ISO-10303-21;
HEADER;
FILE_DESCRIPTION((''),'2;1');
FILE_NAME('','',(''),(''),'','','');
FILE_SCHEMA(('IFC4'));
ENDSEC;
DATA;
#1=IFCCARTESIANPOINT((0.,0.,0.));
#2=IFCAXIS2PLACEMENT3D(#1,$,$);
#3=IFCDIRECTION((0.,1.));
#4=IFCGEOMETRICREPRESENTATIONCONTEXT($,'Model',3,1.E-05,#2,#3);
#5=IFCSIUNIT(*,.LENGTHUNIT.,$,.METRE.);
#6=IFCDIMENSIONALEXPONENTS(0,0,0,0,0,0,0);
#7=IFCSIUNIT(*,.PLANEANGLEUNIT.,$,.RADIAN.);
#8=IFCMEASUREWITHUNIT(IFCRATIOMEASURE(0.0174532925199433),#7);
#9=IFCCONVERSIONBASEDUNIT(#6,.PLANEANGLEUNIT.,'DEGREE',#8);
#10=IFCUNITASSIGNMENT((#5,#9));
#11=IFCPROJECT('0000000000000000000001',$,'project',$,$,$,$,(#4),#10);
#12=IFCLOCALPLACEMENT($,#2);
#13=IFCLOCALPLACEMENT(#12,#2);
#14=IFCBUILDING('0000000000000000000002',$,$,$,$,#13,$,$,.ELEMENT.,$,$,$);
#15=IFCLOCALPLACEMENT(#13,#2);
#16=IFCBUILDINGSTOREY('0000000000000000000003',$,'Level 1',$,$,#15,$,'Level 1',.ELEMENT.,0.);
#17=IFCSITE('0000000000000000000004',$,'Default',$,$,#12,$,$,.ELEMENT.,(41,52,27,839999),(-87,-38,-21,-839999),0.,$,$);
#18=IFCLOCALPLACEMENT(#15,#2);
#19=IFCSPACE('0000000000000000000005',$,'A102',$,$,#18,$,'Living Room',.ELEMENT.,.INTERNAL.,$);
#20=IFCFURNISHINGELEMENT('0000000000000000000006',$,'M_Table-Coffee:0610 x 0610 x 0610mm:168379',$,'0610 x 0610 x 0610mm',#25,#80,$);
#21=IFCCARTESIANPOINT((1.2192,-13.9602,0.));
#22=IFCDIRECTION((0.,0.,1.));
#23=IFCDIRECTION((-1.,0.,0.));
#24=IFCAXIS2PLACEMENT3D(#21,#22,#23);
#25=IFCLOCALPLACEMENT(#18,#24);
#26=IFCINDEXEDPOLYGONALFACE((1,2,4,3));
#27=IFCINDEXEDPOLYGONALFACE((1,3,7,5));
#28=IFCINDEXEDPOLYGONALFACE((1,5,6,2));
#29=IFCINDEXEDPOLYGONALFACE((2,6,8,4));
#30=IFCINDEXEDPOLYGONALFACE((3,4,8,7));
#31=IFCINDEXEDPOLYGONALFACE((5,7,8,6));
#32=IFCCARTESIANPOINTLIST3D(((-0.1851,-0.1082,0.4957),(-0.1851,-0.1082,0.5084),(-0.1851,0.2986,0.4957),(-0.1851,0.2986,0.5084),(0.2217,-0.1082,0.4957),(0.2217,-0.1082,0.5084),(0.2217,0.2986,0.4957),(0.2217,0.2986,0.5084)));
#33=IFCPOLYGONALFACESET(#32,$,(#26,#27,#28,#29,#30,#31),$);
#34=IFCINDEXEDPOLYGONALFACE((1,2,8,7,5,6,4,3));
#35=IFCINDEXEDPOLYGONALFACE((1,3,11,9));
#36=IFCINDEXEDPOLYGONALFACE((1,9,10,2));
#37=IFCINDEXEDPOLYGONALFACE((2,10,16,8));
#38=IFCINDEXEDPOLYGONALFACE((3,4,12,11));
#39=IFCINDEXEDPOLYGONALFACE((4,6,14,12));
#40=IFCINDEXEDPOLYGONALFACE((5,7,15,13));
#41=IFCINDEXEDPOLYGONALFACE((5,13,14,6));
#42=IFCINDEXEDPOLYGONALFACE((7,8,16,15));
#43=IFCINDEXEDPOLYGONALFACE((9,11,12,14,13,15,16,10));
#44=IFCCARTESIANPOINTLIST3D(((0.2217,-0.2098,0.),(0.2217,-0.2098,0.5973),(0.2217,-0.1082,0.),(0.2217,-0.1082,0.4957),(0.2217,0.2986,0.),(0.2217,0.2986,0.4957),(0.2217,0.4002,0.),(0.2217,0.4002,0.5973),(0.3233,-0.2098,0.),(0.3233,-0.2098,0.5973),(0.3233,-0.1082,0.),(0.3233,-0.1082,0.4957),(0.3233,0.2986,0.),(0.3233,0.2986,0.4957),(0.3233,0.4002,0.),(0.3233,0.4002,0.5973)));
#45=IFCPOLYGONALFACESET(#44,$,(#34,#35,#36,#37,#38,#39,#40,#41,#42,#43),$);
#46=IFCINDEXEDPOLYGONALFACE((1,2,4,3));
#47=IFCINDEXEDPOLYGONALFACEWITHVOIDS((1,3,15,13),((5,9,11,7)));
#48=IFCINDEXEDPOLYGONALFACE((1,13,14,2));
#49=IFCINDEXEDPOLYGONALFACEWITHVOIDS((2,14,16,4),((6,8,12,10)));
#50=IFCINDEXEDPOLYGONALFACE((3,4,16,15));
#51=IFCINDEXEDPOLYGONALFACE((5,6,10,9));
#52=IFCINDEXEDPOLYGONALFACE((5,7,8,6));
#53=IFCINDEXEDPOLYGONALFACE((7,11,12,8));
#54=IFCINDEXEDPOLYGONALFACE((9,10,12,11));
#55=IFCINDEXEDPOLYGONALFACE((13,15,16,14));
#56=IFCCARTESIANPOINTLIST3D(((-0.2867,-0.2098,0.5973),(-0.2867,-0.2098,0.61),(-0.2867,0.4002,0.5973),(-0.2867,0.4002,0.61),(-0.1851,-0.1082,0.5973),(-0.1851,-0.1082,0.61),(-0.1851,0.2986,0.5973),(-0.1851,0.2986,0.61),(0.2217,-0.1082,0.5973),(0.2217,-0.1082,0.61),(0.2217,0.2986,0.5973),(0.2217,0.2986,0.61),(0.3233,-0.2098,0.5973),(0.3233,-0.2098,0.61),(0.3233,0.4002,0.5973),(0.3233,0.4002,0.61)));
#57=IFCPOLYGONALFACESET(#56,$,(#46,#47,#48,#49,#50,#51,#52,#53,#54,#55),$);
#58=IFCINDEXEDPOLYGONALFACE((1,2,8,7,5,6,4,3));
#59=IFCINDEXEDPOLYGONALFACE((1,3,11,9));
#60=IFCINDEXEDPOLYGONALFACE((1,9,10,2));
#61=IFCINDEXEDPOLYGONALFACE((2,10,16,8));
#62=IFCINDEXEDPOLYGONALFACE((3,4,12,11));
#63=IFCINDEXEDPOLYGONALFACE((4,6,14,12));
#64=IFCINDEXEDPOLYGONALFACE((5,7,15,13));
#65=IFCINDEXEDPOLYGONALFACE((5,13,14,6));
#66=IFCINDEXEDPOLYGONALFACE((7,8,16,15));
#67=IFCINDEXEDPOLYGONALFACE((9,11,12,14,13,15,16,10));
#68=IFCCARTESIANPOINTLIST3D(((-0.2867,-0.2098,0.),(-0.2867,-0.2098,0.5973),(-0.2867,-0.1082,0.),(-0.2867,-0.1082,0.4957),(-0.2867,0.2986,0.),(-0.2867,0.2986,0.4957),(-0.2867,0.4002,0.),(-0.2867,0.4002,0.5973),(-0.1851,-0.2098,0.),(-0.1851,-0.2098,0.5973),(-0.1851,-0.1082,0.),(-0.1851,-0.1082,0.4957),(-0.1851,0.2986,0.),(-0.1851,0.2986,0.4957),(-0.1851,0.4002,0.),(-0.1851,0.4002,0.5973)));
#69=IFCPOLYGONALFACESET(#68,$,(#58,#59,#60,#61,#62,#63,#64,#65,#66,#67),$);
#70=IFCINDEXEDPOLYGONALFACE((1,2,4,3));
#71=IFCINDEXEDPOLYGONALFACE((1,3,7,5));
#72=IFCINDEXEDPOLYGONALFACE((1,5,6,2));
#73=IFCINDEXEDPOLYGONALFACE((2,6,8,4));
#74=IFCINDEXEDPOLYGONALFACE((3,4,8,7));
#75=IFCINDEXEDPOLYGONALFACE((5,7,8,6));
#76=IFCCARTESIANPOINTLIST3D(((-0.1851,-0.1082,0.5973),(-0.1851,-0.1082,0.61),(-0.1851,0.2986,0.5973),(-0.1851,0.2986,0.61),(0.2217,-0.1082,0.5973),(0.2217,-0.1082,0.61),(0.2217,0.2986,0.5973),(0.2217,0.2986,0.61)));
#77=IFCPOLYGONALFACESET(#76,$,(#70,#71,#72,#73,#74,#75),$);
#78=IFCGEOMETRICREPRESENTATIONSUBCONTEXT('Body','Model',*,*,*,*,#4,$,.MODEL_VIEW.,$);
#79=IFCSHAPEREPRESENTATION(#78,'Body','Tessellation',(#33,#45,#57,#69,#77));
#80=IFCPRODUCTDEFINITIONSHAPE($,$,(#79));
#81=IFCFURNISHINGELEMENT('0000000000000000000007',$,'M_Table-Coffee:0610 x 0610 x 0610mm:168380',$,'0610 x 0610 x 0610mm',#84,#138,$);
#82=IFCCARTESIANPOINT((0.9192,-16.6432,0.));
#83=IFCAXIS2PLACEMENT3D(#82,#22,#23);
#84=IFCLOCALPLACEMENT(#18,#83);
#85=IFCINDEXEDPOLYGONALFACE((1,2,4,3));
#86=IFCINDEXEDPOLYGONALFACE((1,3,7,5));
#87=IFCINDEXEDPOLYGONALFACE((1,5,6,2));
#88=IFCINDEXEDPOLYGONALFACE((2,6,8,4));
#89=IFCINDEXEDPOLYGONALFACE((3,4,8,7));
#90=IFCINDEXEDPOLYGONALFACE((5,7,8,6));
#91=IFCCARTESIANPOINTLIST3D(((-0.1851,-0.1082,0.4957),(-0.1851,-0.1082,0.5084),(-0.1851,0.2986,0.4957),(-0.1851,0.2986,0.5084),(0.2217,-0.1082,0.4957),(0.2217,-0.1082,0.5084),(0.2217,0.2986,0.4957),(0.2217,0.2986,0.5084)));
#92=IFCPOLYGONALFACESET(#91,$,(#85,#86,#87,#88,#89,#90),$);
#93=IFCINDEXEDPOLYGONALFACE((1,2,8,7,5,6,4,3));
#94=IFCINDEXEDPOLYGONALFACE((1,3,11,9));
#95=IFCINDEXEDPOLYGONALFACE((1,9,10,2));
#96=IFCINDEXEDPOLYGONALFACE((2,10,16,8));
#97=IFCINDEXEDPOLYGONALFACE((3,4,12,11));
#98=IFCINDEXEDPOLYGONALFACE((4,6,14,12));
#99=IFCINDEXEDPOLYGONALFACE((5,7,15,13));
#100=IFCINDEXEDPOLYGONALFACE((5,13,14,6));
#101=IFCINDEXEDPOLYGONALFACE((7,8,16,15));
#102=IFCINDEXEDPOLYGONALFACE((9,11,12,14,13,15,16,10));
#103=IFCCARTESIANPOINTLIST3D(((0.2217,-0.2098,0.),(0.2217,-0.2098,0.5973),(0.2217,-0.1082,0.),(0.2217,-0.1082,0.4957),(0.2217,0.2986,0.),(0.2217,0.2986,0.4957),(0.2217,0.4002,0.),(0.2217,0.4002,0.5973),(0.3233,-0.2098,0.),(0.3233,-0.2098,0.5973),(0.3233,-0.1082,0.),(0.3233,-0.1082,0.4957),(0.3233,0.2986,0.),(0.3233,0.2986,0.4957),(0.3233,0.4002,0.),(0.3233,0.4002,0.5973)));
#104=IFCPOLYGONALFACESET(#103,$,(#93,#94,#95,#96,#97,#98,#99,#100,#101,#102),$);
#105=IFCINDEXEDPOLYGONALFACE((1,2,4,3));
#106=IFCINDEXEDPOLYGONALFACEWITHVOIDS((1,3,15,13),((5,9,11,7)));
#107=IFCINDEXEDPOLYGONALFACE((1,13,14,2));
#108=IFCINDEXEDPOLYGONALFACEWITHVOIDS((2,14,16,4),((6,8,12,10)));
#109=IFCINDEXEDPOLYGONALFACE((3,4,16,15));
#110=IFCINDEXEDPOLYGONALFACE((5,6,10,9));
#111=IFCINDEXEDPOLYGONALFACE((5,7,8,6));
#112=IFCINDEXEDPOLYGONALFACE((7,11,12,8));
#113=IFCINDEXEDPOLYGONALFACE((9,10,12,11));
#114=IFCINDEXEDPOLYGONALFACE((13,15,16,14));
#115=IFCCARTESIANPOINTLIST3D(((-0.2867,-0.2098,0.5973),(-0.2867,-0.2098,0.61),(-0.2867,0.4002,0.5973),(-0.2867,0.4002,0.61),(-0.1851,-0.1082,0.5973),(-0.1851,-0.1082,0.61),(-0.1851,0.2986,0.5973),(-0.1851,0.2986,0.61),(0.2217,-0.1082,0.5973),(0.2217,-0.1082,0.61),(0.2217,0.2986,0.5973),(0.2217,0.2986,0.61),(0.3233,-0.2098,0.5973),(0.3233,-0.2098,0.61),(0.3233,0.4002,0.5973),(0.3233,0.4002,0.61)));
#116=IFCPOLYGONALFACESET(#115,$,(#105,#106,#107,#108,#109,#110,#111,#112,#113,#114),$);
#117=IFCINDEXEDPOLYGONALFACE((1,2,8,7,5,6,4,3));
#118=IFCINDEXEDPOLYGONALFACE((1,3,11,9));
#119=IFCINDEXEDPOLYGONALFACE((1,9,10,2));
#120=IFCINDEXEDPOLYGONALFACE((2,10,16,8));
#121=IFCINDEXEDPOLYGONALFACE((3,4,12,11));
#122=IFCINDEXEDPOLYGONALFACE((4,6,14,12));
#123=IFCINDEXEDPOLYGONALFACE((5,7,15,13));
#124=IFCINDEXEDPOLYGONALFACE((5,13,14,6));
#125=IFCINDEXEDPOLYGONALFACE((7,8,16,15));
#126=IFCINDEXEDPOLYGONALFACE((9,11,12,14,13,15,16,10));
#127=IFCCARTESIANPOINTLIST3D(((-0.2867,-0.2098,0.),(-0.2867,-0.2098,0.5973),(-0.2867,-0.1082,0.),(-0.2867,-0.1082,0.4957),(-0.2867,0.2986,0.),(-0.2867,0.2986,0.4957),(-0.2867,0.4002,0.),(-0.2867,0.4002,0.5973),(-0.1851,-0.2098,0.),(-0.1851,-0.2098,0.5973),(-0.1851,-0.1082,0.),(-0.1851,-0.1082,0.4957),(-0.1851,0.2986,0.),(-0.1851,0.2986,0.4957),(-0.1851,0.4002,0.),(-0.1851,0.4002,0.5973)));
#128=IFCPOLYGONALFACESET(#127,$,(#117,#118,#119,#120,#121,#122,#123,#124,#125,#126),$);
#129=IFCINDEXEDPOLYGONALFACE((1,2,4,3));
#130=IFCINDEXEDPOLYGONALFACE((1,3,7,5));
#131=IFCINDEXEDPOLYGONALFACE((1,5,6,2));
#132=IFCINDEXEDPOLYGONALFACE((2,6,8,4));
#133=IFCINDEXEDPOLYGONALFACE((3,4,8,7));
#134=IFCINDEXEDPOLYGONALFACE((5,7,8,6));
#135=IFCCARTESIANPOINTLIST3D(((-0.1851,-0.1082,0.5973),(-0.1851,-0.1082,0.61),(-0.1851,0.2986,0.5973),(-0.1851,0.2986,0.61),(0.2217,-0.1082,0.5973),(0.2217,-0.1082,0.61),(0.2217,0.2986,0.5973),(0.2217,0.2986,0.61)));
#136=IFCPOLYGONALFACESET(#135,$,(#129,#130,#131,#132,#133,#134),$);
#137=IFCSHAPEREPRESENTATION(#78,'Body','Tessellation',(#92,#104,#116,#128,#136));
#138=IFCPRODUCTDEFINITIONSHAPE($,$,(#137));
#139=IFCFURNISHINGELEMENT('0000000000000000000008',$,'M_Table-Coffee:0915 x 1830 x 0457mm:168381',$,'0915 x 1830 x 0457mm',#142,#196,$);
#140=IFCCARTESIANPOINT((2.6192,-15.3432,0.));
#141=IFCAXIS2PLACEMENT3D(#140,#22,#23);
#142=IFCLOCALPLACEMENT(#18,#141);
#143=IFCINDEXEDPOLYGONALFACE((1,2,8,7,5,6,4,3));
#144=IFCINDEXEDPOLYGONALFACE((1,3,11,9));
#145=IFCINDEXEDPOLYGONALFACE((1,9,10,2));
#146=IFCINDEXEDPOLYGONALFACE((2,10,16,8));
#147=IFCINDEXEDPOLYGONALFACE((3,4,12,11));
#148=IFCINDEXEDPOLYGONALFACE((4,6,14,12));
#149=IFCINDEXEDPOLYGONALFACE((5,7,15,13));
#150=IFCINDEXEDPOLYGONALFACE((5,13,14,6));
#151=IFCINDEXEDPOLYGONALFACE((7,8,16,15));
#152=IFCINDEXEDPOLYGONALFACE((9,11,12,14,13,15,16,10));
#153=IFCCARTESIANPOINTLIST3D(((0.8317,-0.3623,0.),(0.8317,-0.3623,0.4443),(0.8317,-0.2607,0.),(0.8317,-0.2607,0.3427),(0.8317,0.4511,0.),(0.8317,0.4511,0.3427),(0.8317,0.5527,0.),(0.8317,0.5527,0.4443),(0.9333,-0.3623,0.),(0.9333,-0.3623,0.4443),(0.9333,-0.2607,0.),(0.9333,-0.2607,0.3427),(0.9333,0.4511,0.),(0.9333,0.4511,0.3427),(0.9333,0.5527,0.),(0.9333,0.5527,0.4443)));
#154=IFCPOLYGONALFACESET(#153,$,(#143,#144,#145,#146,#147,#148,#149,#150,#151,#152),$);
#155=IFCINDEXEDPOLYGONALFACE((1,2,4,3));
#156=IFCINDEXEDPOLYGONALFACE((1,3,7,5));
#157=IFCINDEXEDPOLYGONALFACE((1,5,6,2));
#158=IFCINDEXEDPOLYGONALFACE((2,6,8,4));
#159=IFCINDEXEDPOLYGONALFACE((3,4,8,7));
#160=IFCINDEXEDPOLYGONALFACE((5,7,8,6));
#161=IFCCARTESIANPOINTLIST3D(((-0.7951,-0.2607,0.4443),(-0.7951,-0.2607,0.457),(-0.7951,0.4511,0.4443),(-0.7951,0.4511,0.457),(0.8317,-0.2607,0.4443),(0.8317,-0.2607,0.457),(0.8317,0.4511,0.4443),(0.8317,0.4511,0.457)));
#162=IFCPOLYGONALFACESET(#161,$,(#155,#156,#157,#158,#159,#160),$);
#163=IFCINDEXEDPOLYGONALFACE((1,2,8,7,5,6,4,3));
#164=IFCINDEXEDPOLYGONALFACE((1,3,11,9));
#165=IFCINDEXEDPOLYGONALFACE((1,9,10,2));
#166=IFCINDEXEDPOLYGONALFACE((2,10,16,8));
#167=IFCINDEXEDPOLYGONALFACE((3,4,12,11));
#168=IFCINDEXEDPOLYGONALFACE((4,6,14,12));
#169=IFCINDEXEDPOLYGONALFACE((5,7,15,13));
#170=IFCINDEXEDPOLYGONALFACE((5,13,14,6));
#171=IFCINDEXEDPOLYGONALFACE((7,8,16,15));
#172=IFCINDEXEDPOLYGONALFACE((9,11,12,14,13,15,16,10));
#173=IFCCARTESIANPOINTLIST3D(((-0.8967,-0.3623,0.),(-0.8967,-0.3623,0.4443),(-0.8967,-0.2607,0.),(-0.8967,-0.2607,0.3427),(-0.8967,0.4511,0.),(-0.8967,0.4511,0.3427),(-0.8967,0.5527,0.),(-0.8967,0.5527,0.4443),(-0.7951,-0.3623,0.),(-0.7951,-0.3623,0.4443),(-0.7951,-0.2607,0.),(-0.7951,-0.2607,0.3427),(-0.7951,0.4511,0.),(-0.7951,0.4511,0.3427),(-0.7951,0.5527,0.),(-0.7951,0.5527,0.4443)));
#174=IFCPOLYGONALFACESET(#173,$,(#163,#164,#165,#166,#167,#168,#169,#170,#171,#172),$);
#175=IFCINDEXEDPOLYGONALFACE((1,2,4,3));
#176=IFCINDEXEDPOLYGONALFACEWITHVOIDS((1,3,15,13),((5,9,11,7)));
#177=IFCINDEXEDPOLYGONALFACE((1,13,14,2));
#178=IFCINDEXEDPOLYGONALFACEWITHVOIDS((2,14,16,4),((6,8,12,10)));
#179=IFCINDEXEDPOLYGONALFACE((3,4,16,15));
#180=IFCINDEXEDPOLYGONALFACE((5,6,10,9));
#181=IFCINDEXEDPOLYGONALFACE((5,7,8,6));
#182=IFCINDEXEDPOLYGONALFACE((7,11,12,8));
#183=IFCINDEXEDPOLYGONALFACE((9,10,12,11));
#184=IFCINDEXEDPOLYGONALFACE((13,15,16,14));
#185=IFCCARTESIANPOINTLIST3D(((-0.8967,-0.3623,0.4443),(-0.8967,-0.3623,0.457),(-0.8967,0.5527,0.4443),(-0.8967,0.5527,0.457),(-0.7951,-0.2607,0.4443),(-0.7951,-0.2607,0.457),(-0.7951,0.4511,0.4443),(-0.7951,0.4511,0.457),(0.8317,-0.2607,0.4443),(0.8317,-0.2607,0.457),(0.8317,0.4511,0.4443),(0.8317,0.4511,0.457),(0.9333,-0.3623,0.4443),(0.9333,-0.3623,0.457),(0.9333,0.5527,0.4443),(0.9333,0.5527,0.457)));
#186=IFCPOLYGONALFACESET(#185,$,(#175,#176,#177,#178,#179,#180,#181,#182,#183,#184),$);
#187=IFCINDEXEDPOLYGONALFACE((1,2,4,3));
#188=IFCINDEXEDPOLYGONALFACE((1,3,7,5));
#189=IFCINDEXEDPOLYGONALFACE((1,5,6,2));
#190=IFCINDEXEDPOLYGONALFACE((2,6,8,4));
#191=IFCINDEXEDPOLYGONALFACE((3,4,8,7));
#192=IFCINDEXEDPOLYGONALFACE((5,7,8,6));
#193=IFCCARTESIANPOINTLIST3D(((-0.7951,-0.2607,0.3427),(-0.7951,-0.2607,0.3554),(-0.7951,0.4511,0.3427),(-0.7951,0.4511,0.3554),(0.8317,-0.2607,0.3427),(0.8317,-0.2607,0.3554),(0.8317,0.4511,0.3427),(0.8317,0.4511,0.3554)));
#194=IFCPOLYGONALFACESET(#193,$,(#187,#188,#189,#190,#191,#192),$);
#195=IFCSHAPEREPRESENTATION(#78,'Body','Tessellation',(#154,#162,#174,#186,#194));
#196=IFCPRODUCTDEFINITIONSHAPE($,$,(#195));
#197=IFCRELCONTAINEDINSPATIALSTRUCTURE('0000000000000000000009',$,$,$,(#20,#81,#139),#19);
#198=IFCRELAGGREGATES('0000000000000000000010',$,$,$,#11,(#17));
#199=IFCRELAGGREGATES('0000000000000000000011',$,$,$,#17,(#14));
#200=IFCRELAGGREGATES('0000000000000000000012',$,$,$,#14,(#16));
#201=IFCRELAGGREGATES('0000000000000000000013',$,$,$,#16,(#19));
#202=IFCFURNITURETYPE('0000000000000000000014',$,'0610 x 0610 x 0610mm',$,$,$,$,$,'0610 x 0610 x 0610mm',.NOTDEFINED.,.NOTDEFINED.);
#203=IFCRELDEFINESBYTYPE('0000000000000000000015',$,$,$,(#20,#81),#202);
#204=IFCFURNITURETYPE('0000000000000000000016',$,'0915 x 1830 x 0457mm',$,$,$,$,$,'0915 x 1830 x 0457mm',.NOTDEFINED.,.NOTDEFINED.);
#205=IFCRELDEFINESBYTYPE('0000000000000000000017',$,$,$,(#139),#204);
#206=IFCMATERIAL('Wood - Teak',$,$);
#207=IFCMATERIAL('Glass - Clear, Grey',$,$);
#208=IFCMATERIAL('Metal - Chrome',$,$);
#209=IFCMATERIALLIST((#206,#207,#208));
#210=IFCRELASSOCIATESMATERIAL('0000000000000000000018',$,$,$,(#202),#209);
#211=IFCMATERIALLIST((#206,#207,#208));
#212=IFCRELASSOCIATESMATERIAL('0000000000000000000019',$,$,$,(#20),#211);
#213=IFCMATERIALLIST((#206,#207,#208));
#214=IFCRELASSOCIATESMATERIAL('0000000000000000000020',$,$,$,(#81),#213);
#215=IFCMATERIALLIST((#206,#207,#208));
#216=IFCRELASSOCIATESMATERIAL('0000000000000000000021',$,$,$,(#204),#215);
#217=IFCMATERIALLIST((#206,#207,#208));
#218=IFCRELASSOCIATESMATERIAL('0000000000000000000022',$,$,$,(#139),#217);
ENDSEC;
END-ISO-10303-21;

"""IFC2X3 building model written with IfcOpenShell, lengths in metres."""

from ifc_helpers import new_model, entity, si_unit, converted_unit, direction, frame, origin, origin_2d_with_axis, place, context, subcontext, project, spatial, polyline, rectangle, outline, extrude, source, transform, mapped, material, material_list, type_object, type_shapes, element, save


model = new_model("IFC2X3")

# Units and contexts
model_context = context("Model", 3, precision=1e-05, world=origin(), true_north=direction((0.0, 1.0)))
body_context = subcontext(model_context, "Body", "Model", "MODEL_VIEW")
ifc_project = project(units=[si_unit("LENGTHUNIT", "METRE"), converted_unit("PLANEANGLEUNIT", "DEGREE", entity("IfcRatioMeasure", 0.0174532925199433), si_unit("PLANEANGLEUNIT", "RADIAN"), dimensions=[0, 0, 0, 0, 0, 0, 0])], contexts=[model_context])

# Site, building, storey
site_placement = place(None, origin())
site = spatial("IfcSite", under=ifc_project, at=site_placement, Name="Default", CompositionType="ELEMENT", RefLatitude=(41, 52, 27, 839999), RefLongitude=(-87, -38, -21, -839999), RefElevation=0.0)
building_placement = place(site_placement, origin())
building = spatial("IfcBuilding", under=site, at=building_placement, CompositionType="ELEMENT")
storey_placement = place(building_placement, origin())
storey = spatial("IfcBuildingStorey", under=building, at=storey_placement, Name="Level 1", LongName="Level 1", CompositionType="ELEMENT", Elevation=0.0)

# Shared definitions
space_1_placement = place(storey_placement, origin())
space_1 = spatial("IfcSpace", under=storey, at=space_1_placement, Name="A102", LongName="Living Room", CompositionType="ELEMENT", InteriorOrExteriorSpace="INTERNAL")

# Furnishing elements
ifc_material_1 = material(Name="Wood - Teak")
ifc_material_2 = material(Name="Glass - Clear, Grey")
ifc_material_3 = material(Name="Metal - Chrome")
ifc_material_list_1 = material_list([ifc_material_1, ifc_material_2, ifc_material_3])
ifc_material_list_2 = material_list([ifc_material_1, ifc_material_2, ifc_material_3])
furniture_type_1 = type_object("IfcFurnitureType", Name="0610 x 0610 x 0610mm", ElementType="0610 x 0610 x 0610mm", AssemblyPlace="NOTDEFINED", material=ifc_material_list_2)
shared_shape_1 = source(origin(), body_context, "Body", "SweptSolid", [
    extrude(rectangle(XDim=0.4068, YDim=0.4068, at=origin_2d_with_axis()), frame((0.0183, 0.0952, 0.4957), z_axis=(0.0, 0.0, 1.0), x_axis=(-1.0, 0.0, 0.0)), (0.0, 0.0, 1.0), 0.0127),
    extrude(outline(polyline([(-0.2732, -0.305), (0.324, -0.305), (0.324, 0.305), (-0.2732, 0.305), (-0.2732, 0.2034), (0.2225, 0.2034), (0.2225, -0.2034), (-0.2732, -0.2034), (-0.2732, -0.305)])), frame((0.2217, 0.0952, 0.2732), z_axis=(1.0, 0.0, 0.0), x_axis=(0.0, 0.0, 1.0)), (0.0, 0.0, 1.0), 0.1016),
    extrude(outline(polyline([(-0.305, -0.305), (0.305, -0.305), (0.305, 0.305), (-0.305, 0.305), (-0.305, -0.305)]), holes=[polyline([(-0.2034, -0.2034), (-0.2034, 0.2034), (0.2034, 0.2034), (0.2034, -0.2034), (-0.2034, -0.2034)])]), frame((0.0183, 0.0952, 0.5973), z_axis=(0.0, 0.0, 1.0), x_axis=(-1.0, 0.0, 0.0)), (0.0, 0.0, 1.0), 0.0127),
    extrude(outline(polyline([(-0.305, -0.3241), (0.305, -0.3241), (0.305, 0.2733), (0.2034, 0.2733), (0.2034, -0.2224), (-0.2034, -0.2224), (-0.2034, 0.2733), (-0.305, 0.2733), (-0.305, -0.3241)])), frame((-0.2867, 0.0952, 0.2733), z_axis=(1.0, 0.0, 0.0), x_axis=(0.0, -1.0, 0.0)), (0.0, 0.0, 1.0), 0.1016),
    extrude(rectangle(XDim=0.4068, YDim=0.4068, at=origin_2d_with_axis()), frame((0.0183, 0.0952, 0.5973), z_axis=(0.0, 0.0, 1.0), x_axis=(-1.0, 0.0, 0.0)), (0.0, 0.0, 1.0), 0.0127),
])
type_shapes(furniture_type_1, [shared_shape_1])
furnishing_1_placement = place(space_1_placement, frame((1.2192, -13.9602, 0.0), z_axis=(0.0, 0.0, 1.0), x_axis=(-1.0, 0.0, 0.0)))
element("IfcFurnishingElement", 1, at=furnishing_1_placement, inside=space_1, type_object=furniture_type_1, material=ifc_material_list_1, Name="M_Table-Coffee:0610 x 0610 x 0610mm:168379", ObjectType="0610 x 0610 x 0610mm", context=body_context, shape_type="MappedRepresentation", body=[
    mapped(shared_shape_1, transform((0.0, 0.0, 0.0), scale=1.0)),
])
ifc_material_list_3 = material_list([ifc_material_1, ifc_material_2, ifc_material_3])
furnishing_2_placement = place(space_1_placement, frame((0.9192, -16.6432, 0.0), z_axis=(0.0, 0.0, 1.0), x_axis=(-1.0, 0.0, 0.0)))
element("IfcFurnishingElement", 2, at=furnishing_2_placement, inside=space_1, type_object=furniture_type_1, material=ifc_material_list_3, Name="M_Table-Coffee:0610 x 0610 x 0610mm:168380", ObjectType="0610 x 0610 x 0610mm", context=body_context, shape_type="MappedRepresentation", body=[
    mapped(shared_shape_1, transform((0.0, 0.0, 0.0), scale=1.0)),
])
ifc_material_list_4 = material_list([ifc_material_1, ifc_material_2, ifc_material_3])
ifc_material_list_5 = material_list([ifc_material_1, ifc_material_2, ifc_material_3])
furniture_type_2 = type_object("IfcFurnitureType", Name="0915 x 1830 x 0457mm", ElementType="0915 x 1830 x 0457mm", AssemblyPlace="NOTDEFINED", material=ifc_material_list_5)
shared_shape_2 = source(origin(), body_context, "Body", "SweptSolid", [
    extrude(outline(polyline([(-0.1967, -0.4575), (0.2475, -0.4575), (0.2475, 0.4575), (-0.1967, 0.4575), (-0.1967, 0.3559), (0.146, 0.3559), (0.146, -0.3559), (-0.1967, -0.3559), (-0.1967, -0.4575)])), frame((0.8317, 0.0952, 0.1967), z_axis=(1.0, 0.0, 0.0), x_axis=(0.0, 0.0, 1.0)), (0.0, 0.0, 1.0), 0.1016),
    extrude(rectangle(XDim=1.6268, YDim=0.7118, at=origin_2d_with_axis()), frame((0.0183, 0.0952, 0.4443), z_axis=(0.0, 0.0, 1.0), x_axis=(-1.0, 0.0, 0.0)), (0.0, 0.0, 1.0), 0.0127),
    extrude(outline(polyline([(-0.4575, -0.2476), (0.4575, -0.2476), (0.4575, 0.1968), (0.3559, 0.1968), (0.3559, -0.1459), (-0.3559, -0.1459), (-0.3559, 0.1968), (-0.4575, 0.1968), (-0.4575, -0.2476)])), frame((-0.8967, 0.0952, 0.1968), z_axis=(1.0, 0.0, 0.0), x_axis=(0.0, -1.0, 0.0)), (0.0, 0.0, 1.0), 0.1016),
    extrude(outline(polyline([(-0.915, -0.4575), (0.915, -0.4575), (0.915, 0.4575), (-0.915, 0.4575), (-0.915, -0.4575)]), holes=[polyline([(-0.8134, -0.3559), (-0.8134, 0.3559), (0.8134, 0.3559), (0.8134, -0.3559), (-0.8134, -0.3559)])]), frame((0.0183, 0.0952, 0.4443), z_axis=(0.0, 0.0, 1.0), x_axis=(-1.0, 0.0, 0.0)), (0.0, 0.0, 1.0), 0.0127),
    extrude(rectangle(XDim=1.6268, YDim=0.7118, at=origin_2d_with_axis()), frame((0.0183, 0.0952, 0.3427), z_axis=(0.0, 0.0, 1.0), x_axis=(-1.0, 0.0, 0.0)), (0.0, 0.0, 1.0), 0.0127),
])
type_shapes(furniture_type_2, [shared_shape_2])
furnishing_3_placement = place(space_1_placement, frame((2.6192, -15.3432, 0.0), z_axis=(0.0, 0.0, 1.0), x_axis=(-1.0, 0.0, 0.0)))
element("IfcFurnishingElement", 3, at=furnishing_3_placement, inside=space_1, type_object=furniture_type_2, material=ifc_material_list_4, Name="M_Table-Coffee:0915 x 1830 x 0457mm:168381", ObjectType="0915 x 1830 x 0457mm", context=body_context, shape_type="MappedRepresentation", body=[
    mapped(shared_shape_2, transform((0.0, 0.0, 0.0), scale=1.0)),
])

save(model, "model.ifc")
